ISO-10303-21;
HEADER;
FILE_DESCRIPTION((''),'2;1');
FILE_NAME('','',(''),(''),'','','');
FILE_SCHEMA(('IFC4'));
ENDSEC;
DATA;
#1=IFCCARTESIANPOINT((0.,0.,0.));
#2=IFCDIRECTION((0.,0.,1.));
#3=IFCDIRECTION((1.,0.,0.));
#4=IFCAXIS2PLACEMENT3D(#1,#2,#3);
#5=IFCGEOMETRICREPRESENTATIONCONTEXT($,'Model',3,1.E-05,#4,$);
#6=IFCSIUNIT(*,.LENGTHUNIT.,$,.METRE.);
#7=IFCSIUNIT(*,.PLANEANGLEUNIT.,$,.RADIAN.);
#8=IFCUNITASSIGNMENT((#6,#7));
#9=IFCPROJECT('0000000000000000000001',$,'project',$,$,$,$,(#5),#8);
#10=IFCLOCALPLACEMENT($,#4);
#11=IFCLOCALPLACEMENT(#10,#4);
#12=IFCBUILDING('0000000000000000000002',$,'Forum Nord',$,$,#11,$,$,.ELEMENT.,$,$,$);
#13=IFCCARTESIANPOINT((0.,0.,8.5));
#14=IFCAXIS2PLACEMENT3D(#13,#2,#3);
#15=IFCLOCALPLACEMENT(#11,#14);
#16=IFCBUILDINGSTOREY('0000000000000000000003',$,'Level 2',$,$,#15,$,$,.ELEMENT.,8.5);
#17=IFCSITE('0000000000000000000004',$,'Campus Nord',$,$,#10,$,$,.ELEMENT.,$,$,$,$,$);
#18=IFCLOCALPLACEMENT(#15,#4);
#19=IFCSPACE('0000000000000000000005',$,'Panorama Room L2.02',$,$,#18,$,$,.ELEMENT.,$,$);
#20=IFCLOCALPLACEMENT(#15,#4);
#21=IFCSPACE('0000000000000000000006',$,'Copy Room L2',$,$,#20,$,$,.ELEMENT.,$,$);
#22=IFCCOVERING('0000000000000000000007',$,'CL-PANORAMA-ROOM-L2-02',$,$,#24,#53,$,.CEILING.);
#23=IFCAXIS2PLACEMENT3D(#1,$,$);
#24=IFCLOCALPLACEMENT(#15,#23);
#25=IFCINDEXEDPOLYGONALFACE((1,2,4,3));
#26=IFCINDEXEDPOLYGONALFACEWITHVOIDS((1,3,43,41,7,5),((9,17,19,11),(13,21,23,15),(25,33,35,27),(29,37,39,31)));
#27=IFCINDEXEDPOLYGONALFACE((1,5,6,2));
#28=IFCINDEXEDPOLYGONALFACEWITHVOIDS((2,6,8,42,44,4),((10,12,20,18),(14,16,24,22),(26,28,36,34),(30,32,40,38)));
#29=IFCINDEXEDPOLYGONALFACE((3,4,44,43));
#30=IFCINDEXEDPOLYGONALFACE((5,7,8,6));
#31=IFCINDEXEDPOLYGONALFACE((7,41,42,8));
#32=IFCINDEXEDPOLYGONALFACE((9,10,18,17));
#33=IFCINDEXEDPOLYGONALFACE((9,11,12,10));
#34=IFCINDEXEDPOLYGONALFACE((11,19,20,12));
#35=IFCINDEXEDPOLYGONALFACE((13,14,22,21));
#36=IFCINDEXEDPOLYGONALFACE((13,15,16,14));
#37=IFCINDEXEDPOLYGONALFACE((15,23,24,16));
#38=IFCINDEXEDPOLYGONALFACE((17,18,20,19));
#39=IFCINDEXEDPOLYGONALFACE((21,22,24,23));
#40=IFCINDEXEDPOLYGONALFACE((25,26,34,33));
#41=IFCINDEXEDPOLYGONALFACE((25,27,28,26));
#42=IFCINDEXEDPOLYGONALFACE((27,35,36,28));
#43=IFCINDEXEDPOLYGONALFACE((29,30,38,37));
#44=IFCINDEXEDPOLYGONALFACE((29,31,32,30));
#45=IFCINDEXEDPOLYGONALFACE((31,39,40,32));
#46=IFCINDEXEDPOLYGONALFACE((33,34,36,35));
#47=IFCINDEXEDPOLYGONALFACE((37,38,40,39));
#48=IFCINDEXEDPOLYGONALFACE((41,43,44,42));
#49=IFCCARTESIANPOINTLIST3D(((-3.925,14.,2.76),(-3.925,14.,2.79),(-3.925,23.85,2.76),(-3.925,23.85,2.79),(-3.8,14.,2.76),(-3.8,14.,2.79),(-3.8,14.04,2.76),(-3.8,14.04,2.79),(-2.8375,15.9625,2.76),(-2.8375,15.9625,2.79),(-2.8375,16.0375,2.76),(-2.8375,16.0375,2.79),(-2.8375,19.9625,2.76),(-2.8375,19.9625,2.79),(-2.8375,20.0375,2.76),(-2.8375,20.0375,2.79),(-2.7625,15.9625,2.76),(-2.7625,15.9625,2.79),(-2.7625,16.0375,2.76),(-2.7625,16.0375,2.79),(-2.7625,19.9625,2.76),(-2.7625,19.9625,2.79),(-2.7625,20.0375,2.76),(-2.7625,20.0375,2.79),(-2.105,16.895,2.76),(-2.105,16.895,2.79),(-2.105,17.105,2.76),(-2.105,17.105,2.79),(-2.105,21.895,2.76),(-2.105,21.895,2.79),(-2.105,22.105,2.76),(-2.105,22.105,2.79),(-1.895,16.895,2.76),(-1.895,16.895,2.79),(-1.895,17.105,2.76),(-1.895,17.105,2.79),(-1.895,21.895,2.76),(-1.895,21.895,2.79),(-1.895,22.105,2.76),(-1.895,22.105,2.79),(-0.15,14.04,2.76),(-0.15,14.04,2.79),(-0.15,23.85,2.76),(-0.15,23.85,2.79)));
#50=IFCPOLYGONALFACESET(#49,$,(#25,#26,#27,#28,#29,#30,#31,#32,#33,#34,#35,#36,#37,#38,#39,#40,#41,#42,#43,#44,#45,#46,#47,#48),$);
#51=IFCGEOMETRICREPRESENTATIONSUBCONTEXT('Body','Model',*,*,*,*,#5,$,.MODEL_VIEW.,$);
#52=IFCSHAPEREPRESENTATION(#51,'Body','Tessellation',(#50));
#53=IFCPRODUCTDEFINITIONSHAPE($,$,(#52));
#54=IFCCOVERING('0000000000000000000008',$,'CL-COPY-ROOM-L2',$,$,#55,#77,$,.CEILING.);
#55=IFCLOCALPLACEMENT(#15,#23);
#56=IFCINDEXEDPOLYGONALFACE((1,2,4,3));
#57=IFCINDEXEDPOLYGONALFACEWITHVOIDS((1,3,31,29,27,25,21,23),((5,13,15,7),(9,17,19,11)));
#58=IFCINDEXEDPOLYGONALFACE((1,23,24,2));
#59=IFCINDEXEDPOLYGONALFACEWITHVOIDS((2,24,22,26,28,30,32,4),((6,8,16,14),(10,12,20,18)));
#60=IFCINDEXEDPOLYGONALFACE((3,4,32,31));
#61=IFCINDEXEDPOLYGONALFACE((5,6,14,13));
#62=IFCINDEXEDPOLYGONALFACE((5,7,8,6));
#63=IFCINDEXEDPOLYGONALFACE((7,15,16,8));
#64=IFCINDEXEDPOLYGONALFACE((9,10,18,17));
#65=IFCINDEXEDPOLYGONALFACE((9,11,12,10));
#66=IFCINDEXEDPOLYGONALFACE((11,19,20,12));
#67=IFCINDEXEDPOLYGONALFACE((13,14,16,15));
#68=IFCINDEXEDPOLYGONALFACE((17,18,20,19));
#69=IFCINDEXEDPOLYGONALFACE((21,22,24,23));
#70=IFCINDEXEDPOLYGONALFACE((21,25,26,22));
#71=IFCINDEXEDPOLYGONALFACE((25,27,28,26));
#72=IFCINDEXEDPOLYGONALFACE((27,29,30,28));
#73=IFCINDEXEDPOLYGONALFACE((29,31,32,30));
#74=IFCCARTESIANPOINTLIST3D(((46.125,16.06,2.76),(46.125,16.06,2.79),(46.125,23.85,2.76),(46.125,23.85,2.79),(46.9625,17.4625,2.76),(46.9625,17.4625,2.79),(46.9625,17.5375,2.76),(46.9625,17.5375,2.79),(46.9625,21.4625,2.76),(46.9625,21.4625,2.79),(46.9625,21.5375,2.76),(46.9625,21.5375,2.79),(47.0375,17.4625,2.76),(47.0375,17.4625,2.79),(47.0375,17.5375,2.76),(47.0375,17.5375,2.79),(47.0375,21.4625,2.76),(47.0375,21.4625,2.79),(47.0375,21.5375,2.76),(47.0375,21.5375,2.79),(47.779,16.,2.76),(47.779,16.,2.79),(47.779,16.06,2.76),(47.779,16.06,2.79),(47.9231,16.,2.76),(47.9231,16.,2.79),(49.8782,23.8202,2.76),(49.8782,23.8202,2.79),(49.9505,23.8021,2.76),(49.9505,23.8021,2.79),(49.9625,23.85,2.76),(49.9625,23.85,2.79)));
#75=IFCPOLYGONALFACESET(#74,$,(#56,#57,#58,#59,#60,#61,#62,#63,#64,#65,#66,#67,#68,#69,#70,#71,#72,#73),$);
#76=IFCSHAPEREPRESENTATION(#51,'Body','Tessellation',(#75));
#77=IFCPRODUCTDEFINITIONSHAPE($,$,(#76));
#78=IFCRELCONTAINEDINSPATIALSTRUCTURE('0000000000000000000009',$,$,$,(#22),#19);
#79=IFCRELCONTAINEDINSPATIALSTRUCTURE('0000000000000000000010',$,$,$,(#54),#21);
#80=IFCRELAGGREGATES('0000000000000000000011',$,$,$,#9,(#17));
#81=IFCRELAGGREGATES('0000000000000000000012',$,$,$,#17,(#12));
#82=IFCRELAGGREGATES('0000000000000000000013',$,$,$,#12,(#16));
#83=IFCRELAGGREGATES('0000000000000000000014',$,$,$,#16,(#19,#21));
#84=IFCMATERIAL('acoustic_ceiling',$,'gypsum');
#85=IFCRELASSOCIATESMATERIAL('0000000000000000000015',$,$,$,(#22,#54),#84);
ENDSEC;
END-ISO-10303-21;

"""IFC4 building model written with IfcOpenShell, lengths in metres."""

from ifc_helpers import new_model, si_unit, frame, origin_with_axes, place, context, subcontext, project, spatial, polyline, outline, extrude, material, element, save


model = new_model("IFC4")

# Units and contexts
model_context = context("Model", 3, precision=1e-05, world=origin_with_axes())
body_context = subcontext(model_context, "Body", "Model", "MODEL_VIEW")
ifc_project = project(units=[si_unit("LENGTHUNIT", "METRE"), si_unit("PLANEANGLEUNIT", "RADIAN")], contexts=[model_context])

# Site, building, storey, space
site_placement = place(None, origin_with_axes())
site = spatial("IfcSite", under=ifc_project, at=site_placement, Name="Campus Nord", CompositionType="ELEMENT")
building_placement = place(site_placement, origin_with_axes())
building = spatial("IfcBuilding", under=site, at=building_placement, Name="Forum Nord", CompositionType="ELEMENT")
storey_placement = place(building_placement, frame((0.0, 0.0, 8.5), z_axis=(0.0, 0.0, 1.0), x_axis=(1.0, 0.0, 0.0)))
storey = spatial("IfcBuildingStorey", under=building, at=storey_placement, Name="Level 2", CompositionType="ELEMENT", Elevation=8.5)
space_1_placement = place(storey_placement, origin_with_axes())
space_1 = spatial("IfcSpace", under=storey, at=space_1_placement, Name="Panorama Room L2.02", CompositionType="ELEMENT")

# Covering, openings
ifc_material = material(Name="acoustic_ceiling", Category="gypsum")
covering_1_placement = place(storey_placement, frame((0.0, 0.0, 2.76), z_axis=(0.0, 0.0, 1.0), x_axis=(1.0, 0.0, 0.0)))
covering_1 = element("IfcCovering", 1, at=covering_1_placement, inside=space_1, material=ifc_material, Name="CL-PANORAMA-ROOM-L2-02", PredefinedType="CEILING", context=body_context, shape_type="SweptSolid", body=[
    extrude(outline(polyline([(-3.925, 23.85), (-3.925, 14.0), (-3.8, 14.0), (-3.8, 14.04), (-0.15, 14.04), (-0.15, 23.85), (-3.925, 23.85)])), origin_with_axes(), (0.0, 0.0, 1.0), 0.03),
])
opening_1_placement = place(storey_placement, frame((0.0, 0.0, 2.71), z_axis=(0.0, 0.0, 1.0), x_axis=(1.0, 0.0, 0.0)))
element("IfcOpeningElement", 2, at=opening_1_placement, cuts=covering_1, context=body_context, shape_type="SweptSolid", body=[
    extrude(outline(polyline([(-2.105, 16.895), (-1.895, 16.895), (-1.895, 17.105), (-2.105, 17.105), (-2.105, 16.895)])), origin_with_axes(), (0.0, 0.0, 1.0), 0.13),
])
opening_2_placement = place(storey_placement, frame((0.0, 0.0, 2.71), z_axis=(0.0, 0.0, 1.0), x_axis=(1.0, 0.0, 0.0)))
element("IfcOpeningElement", 3, at=opening_2_placement, cuts=covering_1, context=body_context, shape_type="SweptSolid", body=[
    extrude(outline(polyline([(-2.105, 21.895), (-1.895, 21.895), (-1.895, 22.105), (-2.105, 22.105), (-2.105, 21.895)])), origin_with_axes(), (0.0, 0.0, 1.0), 0.13),
])
opening_3_placement = place(storey_placement, frame((0.0, 0.0, 2.71), z_axis=(0.0, 0.0, 1.0), x_axis=(1.0, 0.0, 0.0)))
element("IfcOpeningElement", 4, at=opening_3_placement, cuts=covering_1, context=body_context, shape_type="SweptSolid", body=[
    extrude(outline(polyline([(-2.8375, 15.9625), (-2.7625, 15.9625), (-2.7625, 16.0375), (-2.8375, 16.0375), (-2.8375, 15.9625)])), origin_with_axes(), (0.0, 0.0, 1.0), 0.13),
])
opening_4_placement = place(storey_placement, frame((0.0, 0.0, 2.71), z_axis=(0.0, 0.0, 1.0), x_axis=(1.0, 0.0, 0.0)))
element("IfcOpeningElement", 5, at=opening_4_placement, cuts=covering_1, context=body_context, shape_type="SweptSolid", body=[
    extrude(outline(polyline([(-2.8375, 19.9625), (-2.7625, 19.9625), (-2.7625, 20.0375), (-2.8375, 20.0375), (-2.8375, 19.9625)])), origin_with_axes(), (0.0, 0.0, 1.0), 0.13),
])

# Shared definitions
space_2_placement = place(storey_placement, origin_with_axes())
space_2 = spatial("IfcSpace", under=storey, at=space_2_placement, Name="Copy Room L2", CompositionType="ELEMENT")

# Covering, openings
covering_2_placement = place(storey_placement, frame((0.0, 0.0, 2.76), z_axis=(0.0, 0.0, 1.0), x_axis=(1.0, 0.0, 0.0)))
covering_2 = element("IfcCovering", 6, at=covering_2_placement, inside=space_2, material=ifc_material, Name="CL-COPY-ROOM-L2", PredefinedType="CEILING", context=body_context, shape_type="SweptSolid", body=[
    extrude(outline(polyline([(46.125, 16.06), (47.779, 16.06), (47.779, 16.0), (47.9231, 16.0), (49.8782, 23.8202), (49.9505, 23.8021), (49.9625, 23.85), (46.125, 23.85), (46.125, 16.06)])), origin_with_axes(), (0.0, 0.0, 1.0), 0.03),
])
opening_5_placement = place(storey_placement, frame((0.0, 0.0, 2.71), z_axis=(0.0, 0.0, 1.0), x_axis=(1.0, 0.0, 0.0)))
element("IfcOpeningElement", 7, at=opening_5_placement, cuts=covering_2, context=body_context, shape_type="SweptSolid", body=[
    extrude(outline(polyline([(46.9625, 17.4625), (47.0375, 17.4625), (47.0375, 17.5375), (46.9625, 17.5375), (46.9625, 17.4625)])), origin_with_axes(), (0.0, 0.0, 1.0), 0.13),
])
opening_6_placement = place(storey_placement, frame((0.0, 0.0, 2.71), z_axis=(0.0, 0.0, 1.0), x_axis=(1.0, 0.0, 0.0)))
element("IfcOpeningElement", 8, at=opening_6_placement, cuts=covering_2, context=body_context, shape_type="SweptSolid", body=[
    extrude(outline(polyline([(46.9625, 21.4625), (47.0375, 21.4625), (47.0375, 21.5375), (46.9625, 21.5375), (46.9625, 21.4625)])), origin_with_axes(), (0.0, 0.0, 1.0), 0.13),
])

save(model, "model.ifc")
